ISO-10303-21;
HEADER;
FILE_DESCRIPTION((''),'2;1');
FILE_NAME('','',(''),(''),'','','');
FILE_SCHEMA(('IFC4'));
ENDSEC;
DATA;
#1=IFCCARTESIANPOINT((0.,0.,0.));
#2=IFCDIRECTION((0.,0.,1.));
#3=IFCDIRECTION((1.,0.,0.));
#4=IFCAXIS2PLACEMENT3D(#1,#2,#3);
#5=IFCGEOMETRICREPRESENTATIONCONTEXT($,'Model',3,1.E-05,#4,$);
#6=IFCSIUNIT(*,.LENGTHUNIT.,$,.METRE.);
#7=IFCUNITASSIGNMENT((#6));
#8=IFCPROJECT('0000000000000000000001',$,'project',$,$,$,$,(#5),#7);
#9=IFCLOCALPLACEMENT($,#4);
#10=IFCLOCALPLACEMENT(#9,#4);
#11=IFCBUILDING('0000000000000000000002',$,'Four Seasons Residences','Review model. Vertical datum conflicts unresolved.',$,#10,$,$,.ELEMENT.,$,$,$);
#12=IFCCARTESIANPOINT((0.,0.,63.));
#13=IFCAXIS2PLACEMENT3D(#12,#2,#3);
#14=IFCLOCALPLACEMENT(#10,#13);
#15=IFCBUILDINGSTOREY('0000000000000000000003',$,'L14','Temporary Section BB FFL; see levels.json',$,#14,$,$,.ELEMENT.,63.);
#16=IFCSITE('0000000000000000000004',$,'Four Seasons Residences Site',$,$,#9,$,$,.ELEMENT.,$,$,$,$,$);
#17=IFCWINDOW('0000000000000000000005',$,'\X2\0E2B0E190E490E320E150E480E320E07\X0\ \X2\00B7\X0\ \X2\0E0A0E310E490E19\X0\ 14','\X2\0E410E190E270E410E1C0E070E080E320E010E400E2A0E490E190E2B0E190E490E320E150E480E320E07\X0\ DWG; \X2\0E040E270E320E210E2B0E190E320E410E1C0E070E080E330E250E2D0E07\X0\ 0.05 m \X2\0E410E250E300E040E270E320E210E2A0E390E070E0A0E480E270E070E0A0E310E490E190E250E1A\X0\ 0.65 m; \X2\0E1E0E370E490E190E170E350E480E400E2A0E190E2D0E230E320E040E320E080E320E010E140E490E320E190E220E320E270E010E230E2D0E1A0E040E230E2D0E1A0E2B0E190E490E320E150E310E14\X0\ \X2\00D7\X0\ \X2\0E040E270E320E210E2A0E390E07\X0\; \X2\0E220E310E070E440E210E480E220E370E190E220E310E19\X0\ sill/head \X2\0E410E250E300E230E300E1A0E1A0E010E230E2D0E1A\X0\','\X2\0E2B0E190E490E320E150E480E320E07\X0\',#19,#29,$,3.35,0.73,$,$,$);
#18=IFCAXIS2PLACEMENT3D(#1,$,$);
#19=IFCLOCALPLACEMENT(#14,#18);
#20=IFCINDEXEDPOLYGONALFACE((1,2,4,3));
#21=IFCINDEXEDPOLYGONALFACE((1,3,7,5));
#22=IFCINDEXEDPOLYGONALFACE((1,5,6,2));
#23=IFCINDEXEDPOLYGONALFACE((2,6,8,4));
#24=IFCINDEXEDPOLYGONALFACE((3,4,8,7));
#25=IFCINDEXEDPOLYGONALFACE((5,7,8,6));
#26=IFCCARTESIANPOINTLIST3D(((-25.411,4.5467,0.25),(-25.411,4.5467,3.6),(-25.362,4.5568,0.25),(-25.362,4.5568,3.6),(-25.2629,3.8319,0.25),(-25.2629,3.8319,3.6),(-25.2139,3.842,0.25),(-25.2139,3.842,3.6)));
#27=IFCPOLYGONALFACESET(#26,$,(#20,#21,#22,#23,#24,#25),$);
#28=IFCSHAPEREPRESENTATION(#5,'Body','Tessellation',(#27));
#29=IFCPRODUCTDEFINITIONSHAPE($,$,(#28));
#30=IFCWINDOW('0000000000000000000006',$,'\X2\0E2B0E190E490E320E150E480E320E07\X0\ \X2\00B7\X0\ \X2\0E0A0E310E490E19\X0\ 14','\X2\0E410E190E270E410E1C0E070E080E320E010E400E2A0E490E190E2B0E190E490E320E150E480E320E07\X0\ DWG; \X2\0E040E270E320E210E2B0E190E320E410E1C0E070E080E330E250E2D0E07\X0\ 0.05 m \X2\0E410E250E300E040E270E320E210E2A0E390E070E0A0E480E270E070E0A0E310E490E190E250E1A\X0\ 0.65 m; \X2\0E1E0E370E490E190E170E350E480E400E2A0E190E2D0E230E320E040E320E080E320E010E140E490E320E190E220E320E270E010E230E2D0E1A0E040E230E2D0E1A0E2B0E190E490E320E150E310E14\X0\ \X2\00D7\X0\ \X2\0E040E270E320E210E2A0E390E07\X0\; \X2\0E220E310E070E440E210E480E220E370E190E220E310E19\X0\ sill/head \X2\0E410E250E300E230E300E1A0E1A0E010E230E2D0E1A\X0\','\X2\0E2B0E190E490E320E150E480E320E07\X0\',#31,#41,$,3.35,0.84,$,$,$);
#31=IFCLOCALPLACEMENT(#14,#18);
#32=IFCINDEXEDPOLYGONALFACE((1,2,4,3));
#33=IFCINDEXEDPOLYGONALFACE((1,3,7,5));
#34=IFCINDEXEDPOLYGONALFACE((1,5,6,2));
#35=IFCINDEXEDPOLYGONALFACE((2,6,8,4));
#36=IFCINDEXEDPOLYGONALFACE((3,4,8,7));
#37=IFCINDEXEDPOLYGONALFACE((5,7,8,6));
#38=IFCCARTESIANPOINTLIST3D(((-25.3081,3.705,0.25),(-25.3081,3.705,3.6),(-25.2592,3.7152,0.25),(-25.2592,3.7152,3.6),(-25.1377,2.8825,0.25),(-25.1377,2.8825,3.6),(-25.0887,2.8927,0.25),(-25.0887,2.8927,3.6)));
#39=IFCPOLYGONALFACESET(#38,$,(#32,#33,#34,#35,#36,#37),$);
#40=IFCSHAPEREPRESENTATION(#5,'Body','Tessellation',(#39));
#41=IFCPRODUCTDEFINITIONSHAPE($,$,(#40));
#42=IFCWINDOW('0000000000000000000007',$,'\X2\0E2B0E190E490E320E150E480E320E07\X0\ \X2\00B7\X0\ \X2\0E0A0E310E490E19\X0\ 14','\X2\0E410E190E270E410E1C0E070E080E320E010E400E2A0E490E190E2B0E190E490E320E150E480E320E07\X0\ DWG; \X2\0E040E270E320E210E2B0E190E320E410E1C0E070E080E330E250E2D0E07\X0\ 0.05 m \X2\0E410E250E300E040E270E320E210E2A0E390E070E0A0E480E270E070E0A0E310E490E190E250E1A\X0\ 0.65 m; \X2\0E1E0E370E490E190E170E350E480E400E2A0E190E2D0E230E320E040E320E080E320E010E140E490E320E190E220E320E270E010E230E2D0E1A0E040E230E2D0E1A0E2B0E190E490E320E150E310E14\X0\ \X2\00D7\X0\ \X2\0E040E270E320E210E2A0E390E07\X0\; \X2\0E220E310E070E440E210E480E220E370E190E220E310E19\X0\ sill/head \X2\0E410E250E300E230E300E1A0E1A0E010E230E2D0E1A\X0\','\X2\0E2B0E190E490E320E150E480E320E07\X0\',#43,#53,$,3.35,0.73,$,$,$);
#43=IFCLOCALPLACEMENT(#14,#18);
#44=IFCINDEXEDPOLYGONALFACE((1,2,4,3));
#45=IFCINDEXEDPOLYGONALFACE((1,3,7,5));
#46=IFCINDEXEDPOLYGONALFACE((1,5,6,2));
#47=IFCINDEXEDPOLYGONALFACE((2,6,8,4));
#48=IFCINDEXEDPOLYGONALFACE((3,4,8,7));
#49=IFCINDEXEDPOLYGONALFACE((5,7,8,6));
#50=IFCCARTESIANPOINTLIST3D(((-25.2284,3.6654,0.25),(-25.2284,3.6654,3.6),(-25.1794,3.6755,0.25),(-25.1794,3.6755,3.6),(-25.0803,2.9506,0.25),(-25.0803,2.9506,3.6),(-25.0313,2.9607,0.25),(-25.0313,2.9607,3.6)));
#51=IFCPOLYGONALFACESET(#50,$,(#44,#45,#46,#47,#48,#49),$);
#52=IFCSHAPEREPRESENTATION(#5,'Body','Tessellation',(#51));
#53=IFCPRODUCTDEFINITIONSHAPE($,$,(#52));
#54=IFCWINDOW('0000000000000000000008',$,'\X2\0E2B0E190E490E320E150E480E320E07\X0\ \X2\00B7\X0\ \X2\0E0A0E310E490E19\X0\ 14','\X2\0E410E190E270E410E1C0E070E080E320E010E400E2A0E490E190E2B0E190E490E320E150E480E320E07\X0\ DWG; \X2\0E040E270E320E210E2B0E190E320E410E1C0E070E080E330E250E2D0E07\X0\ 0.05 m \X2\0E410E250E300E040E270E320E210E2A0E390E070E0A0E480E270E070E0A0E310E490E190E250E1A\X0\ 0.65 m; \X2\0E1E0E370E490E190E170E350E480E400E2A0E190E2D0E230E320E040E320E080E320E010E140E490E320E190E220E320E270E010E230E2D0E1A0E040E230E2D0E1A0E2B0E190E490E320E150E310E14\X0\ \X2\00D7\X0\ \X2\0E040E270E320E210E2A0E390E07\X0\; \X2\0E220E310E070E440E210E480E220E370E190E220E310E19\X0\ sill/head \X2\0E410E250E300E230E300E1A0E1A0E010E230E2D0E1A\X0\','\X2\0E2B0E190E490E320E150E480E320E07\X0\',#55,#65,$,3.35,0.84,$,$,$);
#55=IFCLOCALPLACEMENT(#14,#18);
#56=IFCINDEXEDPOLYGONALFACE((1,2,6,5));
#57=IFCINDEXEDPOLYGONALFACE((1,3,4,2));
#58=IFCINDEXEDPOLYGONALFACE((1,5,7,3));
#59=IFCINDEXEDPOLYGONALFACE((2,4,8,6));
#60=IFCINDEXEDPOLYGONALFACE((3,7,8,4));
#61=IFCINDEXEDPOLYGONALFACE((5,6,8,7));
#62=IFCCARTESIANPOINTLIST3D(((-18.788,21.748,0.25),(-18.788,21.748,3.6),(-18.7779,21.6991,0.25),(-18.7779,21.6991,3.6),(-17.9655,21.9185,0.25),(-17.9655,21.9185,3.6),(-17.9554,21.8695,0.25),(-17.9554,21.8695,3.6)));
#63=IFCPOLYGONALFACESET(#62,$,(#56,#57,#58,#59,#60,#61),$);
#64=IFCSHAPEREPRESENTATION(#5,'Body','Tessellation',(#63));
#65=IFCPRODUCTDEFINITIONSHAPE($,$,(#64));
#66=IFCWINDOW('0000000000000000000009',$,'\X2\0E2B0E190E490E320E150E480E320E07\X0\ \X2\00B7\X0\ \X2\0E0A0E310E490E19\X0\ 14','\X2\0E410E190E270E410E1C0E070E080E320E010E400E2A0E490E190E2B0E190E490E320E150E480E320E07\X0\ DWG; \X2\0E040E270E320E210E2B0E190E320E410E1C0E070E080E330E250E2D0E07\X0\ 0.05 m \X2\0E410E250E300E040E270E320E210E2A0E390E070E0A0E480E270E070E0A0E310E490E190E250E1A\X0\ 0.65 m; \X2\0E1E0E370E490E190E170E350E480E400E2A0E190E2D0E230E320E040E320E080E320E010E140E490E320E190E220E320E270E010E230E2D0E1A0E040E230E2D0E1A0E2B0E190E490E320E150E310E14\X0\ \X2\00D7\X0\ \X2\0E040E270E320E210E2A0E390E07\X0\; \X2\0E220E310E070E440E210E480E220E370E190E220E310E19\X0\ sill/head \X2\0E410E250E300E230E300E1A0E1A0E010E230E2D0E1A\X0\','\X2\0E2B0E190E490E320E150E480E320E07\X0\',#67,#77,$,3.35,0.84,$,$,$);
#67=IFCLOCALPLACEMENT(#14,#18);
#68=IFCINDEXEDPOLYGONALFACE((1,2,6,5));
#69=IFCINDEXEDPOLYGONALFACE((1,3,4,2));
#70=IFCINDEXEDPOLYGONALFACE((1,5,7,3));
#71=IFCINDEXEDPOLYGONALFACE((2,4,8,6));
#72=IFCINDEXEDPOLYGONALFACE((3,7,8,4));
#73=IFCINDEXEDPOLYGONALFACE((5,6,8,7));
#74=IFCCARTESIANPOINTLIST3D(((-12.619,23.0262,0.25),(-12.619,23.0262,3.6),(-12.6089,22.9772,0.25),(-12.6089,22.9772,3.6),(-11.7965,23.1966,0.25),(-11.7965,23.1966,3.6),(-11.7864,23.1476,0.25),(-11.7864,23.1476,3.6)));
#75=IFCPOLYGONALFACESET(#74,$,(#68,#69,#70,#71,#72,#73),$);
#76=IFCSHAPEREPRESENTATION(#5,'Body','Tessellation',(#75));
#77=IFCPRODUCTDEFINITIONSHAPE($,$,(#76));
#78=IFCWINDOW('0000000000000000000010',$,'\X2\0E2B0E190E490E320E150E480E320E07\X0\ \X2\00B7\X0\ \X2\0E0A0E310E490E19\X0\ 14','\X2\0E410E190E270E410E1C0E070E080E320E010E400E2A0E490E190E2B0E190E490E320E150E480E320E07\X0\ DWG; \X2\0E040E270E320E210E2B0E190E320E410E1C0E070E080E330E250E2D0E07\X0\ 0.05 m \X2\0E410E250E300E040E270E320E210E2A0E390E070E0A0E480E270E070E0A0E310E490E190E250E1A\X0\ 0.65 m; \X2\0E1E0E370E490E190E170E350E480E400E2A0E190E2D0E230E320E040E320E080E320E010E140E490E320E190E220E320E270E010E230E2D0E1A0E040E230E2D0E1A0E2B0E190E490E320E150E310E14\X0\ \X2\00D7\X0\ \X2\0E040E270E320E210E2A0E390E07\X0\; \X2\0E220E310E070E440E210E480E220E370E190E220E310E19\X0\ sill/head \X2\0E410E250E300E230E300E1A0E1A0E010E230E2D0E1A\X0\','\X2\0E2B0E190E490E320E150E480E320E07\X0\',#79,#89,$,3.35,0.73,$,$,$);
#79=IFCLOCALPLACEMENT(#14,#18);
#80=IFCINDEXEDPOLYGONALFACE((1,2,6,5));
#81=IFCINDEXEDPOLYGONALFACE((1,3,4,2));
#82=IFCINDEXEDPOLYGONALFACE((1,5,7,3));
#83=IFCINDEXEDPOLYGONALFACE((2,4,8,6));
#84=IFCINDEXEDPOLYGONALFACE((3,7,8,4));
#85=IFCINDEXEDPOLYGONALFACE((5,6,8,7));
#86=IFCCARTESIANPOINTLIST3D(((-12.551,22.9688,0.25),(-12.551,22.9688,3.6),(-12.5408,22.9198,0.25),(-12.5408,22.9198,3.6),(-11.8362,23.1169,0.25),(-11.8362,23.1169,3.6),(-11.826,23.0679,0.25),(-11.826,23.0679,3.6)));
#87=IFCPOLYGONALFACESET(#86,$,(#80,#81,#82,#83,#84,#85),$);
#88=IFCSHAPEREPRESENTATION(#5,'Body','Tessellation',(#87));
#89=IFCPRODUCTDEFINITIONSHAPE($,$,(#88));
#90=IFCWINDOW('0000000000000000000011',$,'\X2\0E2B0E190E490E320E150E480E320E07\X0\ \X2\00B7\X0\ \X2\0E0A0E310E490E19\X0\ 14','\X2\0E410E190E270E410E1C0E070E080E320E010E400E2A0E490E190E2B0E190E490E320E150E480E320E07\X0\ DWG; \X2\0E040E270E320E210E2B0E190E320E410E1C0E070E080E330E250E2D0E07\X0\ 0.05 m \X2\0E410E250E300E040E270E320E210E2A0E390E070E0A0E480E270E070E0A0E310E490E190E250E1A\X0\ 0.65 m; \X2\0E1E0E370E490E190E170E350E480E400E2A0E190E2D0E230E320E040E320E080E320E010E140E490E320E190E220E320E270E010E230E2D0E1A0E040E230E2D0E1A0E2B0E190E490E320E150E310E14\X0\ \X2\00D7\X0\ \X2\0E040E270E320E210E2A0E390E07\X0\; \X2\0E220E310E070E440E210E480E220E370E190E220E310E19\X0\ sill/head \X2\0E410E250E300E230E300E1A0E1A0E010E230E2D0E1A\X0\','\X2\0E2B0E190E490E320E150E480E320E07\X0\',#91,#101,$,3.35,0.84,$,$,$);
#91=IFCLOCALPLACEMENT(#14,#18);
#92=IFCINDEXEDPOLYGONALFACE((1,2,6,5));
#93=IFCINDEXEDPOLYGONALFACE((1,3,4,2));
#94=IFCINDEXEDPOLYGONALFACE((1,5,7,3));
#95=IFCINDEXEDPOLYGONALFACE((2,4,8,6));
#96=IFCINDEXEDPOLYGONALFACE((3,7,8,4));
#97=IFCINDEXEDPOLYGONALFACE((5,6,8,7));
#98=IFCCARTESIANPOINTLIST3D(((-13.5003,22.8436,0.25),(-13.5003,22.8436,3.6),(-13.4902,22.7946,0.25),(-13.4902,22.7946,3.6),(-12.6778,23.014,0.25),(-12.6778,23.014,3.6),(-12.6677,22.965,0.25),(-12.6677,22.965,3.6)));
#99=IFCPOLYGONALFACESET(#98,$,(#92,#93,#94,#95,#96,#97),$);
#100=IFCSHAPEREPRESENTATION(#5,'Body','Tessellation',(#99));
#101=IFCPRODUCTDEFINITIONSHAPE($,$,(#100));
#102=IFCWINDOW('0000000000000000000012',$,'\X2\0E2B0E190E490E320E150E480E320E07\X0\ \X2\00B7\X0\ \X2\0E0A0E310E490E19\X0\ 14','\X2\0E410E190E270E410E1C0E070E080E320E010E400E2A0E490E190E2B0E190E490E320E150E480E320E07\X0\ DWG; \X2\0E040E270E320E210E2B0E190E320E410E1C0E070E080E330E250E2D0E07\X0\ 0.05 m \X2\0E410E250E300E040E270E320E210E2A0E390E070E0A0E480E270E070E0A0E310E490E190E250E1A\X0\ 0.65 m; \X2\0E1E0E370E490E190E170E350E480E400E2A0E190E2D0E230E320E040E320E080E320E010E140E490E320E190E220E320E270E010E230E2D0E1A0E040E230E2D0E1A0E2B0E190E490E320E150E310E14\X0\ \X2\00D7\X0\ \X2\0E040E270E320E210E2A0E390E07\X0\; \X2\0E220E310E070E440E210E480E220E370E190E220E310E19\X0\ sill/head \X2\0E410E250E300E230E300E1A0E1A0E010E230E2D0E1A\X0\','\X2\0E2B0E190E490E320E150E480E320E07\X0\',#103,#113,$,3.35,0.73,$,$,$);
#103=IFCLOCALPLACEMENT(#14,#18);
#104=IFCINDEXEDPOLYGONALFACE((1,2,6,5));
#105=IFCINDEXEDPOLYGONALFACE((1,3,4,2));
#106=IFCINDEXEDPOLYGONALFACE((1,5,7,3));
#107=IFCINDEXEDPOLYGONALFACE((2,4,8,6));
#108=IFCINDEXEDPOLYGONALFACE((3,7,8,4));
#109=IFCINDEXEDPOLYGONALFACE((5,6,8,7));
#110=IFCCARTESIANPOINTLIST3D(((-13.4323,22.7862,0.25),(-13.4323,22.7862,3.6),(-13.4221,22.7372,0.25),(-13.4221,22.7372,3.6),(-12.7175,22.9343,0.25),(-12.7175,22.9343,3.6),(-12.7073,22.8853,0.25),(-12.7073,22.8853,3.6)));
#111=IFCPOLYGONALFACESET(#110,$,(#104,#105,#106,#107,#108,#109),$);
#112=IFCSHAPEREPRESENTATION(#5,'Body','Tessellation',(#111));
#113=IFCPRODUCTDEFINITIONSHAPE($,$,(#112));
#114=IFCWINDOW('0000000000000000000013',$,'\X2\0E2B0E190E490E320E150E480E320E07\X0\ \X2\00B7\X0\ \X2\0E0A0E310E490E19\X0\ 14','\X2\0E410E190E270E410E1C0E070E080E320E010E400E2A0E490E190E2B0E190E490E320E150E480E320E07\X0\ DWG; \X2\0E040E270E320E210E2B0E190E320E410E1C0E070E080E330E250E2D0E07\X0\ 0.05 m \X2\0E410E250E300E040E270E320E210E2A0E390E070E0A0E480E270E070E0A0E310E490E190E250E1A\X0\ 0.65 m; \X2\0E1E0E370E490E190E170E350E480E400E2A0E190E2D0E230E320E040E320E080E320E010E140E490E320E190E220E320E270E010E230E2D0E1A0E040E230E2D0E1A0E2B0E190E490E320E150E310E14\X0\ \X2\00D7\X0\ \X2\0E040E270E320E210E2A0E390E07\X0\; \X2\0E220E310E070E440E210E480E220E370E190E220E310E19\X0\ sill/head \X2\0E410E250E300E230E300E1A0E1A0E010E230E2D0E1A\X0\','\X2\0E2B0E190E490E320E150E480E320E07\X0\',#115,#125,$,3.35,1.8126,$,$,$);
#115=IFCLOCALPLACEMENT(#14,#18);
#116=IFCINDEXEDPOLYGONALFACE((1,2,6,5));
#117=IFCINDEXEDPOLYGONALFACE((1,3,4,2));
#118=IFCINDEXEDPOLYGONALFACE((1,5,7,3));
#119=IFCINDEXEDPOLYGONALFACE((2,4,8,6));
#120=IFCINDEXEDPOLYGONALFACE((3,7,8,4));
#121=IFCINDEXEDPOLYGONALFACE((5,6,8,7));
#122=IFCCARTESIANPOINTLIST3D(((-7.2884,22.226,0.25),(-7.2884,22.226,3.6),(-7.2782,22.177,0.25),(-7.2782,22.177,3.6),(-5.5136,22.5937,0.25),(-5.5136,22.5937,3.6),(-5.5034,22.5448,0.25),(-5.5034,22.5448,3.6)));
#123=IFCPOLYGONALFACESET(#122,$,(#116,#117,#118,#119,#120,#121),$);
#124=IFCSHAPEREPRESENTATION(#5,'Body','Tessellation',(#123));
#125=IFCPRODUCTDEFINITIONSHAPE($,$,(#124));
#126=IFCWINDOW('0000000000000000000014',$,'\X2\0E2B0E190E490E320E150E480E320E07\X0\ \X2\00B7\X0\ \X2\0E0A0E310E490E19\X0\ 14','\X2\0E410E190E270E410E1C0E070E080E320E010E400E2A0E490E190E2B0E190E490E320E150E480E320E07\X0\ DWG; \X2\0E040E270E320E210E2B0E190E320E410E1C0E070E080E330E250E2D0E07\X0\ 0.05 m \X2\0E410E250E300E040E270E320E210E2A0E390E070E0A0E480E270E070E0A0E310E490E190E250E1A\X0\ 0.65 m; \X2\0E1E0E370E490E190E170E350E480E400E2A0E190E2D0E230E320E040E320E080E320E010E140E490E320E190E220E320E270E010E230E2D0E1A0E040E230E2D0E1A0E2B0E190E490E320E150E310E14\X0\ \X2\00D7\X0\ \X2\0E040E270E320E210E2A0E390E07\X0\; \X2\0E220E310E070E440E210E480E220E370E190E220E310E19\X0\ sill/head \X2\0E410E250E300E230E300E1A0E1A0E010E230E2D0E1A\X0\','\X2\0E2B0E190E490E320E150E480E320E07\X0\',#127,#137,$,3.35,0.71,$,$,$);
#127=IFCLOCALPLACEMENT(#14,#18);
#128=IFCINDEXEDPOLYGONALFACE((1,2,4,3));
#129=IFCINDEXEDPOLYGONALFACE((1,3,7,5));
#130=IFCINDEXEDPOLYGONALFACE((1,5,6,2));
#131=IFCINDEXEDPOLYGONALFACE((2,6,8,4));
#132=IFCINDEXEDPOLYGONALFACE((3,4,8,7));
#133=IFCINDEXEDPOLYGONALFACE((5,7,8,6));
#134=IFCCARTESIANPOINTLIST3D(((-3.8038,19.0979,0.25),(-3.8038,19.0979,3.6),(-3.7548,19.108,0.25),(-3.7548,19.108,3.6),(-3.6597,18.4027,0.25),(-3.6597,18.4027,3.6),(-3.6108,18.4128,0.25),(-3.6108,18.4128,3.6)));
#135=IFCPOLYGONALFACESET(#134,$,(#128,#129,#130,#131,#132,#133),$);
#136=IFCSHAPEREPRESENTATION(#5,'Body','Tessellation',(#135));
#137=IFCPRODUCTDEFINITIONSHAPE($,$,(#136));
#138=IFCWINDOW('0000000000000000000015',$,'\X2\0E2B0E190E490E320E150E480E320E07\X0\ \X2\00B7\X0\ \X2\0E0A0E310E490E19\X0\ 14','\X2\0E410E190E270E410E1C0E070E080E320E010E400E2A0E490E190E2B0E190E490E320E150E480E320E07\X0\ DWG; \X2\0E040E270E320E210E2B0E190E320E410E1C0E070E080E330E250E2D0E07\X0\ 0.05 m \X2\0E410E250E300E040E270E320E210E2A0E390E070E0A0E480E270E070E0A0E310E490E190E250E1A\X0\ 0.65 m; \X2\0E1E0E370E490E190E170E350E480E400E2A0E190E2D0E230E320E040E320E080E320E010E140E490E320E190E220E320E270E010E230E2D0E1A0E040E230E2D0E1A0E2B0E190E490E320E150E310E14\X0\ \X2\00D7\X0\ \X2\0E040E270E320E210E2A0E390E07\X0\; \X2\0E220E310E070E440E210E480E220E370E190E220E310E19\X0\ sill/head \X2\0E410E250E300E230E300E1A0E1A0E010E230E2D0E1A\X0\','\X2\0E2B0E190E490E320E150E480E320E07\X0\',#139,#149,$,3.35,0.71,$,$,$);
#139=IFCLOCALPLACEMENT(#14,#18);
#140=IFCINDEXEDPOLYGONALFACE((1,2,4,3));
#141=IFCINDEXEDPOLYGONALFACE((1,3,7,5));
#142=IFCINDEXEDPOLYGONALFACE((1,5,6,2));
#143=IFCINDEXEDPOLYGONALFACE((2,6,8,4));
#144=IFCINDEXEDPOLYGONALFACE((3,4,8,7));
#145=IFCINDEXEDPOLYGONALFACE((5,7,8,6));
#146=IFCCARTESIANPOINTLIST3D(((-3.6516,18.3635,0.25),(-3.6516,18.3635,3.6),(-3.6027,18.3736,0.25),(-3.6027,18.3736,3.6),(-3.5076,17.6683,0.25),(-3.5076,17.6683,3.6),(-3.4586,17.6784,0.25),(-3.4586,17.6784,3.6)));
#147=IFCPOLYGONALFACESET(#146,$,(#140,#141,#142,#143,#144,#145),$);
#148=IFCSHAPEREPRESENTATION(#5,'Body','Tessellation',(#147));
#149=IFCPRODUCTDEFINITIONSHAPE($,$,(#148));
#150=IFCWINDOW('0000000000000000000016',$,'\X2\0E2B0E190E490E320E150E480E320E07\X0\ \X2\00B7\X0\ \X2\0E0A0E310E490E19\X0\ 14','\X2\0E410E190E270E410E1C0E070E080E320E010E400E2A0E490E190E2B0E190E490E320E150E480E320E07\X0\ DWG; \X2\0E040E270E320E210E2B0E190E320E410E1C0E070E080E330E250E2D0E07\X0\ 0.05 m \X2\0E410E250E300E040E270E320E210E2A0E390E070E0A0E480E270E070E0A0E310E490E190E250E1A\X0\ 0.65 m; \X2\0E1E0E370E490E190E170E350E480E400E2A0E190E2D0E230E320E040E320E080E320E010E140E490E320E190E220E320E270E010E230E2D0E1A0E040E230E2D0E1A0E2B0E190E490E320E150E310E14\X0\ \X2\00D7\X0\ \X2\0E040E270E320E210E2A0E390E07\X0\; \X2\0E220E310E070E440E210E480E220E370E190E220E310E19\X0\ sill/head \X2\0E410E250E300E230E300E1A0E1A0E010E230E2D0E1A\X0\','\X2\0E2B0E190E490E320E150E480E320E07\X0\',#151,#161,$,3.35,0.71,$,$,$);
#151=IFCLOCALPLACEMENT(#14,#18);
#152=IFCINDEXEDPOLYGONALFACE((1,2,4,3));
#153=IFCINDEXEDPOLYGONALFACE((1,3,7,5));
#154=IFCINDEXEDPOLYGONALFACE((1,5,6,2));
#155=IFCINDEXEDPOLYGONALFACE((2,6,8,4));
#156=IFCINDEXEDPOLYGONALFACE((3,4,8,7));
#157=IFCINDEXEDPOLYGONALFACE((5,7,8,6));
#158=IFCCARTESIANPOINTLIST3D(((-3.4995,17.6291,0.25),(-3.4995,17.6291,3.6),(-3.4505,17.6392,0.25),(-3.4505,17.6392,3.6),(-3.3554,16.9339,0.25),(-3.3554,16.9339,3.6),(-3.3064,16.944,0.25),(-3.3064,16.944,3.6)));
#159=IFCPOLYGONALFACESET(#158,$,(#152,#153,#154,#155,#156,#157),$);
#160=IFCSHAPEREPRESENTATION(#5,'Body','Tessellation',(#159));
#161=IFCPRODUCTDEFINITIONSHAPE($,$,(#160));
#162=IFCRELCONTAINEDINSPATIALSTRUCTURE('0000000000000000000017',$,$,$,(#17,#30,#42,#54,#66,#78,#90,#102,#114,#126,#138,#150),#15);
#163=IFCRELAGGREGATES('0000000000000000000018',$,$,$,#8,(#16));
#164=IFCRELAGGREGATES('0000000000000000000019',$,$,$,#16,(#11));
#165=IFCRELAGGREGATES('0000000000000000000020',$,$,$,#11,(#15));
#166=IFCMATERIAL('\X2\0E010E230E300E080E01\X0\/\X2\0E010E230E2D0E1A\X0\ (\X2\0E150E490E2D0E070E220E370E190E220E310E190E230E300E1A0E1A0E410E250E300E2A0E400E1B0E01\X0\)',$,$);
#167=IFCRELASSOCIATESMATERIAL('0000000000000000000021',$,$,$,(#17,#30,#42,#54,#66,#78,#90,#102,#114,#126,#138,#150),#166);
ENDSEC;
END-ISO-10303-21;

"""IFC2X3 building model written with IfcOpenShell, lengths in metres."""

from ifc_helpers import new_model, si_unit, frame, origin_with_axes, place, context, project, spatial, polyline, outline, extrude, material, element, save


model = new_model("IFC2X3")

# Units and contexts
model_context = context("Model", 3, precision=1e-05, world=origin_with_axes())
ifc_project = project(units=[si_unit("LENGTHUNIT", "METRE")], contexts=[model_context])

# Site, building, storey
site_placement = place(None, origin_with_axes())
site = spatial("IfcSite", under=ifc_project, at=site_placement, Name="Four Seasons Residences Site", CompositionType="ELEMENT")
building_placement = place(site_placement, origin_with_axes())
building = spatial("IfcBuilding", under=site, at=building_placement, Name="Four Seasons Residences", Description="Review model. Vertical datum conflicts unresolved.", CompositionType="ELEMENT")
storey_placement = place(building_placement, frame((0.0, 0.0, 63.0), z_axis=(0.0, 0.0, 1.0), x_axis=(1.0, 0.0, 0.0)))
storey = spatial("IfcBuildingStorey", under=building, at=storey_placement, Name="L14", Description="Temporary Section BB FFL; see levels.json", CompositionType="ELEMENT", Elevation=63.0)

# Windows
ifc_material = material(Name="กระจก/กรอบ (ต้องยืนยันระบบและสเปก)")
window_1_placement = place(storey_placement, origin_with_axes())
element("IfcWindow", 1, at=window_1_placement, inside=storey, material=ifc_material, Name="หน้าต่าง · ชั้น 14", Description="แนวแผงจากเส้นหน้าต่าง DWG; ความหนาแผงจำลอง 0.05 m และความสูงช่วงชั้นลบ 0.65 m; พื้นที่เสนอราคาจากด้านยาวกรอบครอบหน้าตัด × ความสูง; ยังไม่ยืนยัน sill/head และระบบกรอบ", ObjectType="หน้าต่าง", OverallHeight=3.35, OverallWidth=0.73, context=model_context, shape_type="SweptSolid", body=[
    extrude(outline(polyline([(-25.2139, 3.842), (-25.2629, 3.8319), (-25.411, 4.5467), (-25.362, 4.5568), (-25.2139, 3.842)])), frame((0.0, 0.0, 0.25), z_axis=(0.0, 0.0, 1.0), x_axis=(1.0, 0.0, 0.0)), (0.0, 0.0, 1.0), 3.35),
])
window_2_placement = place(storey_placement, origin_with_axes())
element("IfcWindow", 2, at=window_2_placement, inside=storey, material=ifc_material, Name="หน้าต่าง · ชั้น 14", Description="แนวแผงจากเส้นหน้าต่าง DWG; ความหนาแผงจำลอง 0.05 m และความสูงช่วงชั้นลบ 0.65 m; พื้นที่เสนอราคาจากด้านยาวกรอบครอบหน้าตัด × ความสูง; ยังไม่ยืนยัน sill/head และระบบกรอบ", ObjectType="หน้าต่าง", OverallHeight=3.35, OverallWidth=0.84, context=model_context, shape_type="SweptSolid", body=[
    extrude(outline(polyline([(-25.0887, 2.8927), (-25.1377, 2.8825), (-25.3081, 3.705), (-25.2592, 3.7152), (-25.0887, 2.8927)])), frame((0.0, 0.0, 0.25), z_axis=(0.0, 0.0, 1.0), x_axis=(1.0, 0.0, 0.0)), (0.0, 0.0, 1.0), 3.35),
])
window_3_placement = place(storey_placement, origin_with_axes())
element("IfcWindow", 3, at=window_3_placement, inside=storey, material=ifc_material, Name="หน้าต่าง · ชั้น 14", Description="แนวแผงจากเส้นหน้าต่าง DWG; ความหนาแผงจำลอง 0.05 m และความสูงช่วงชั้นลบ 0.65 m; พื้นที่เสนอราคาจากด้านยาวกรอบครอบหน้าตัด × ความสูง; ยังไม่ยืนยัน sill/head และระบบกรอบ", ObjectType="หน้าต่าง", OverallHeight=3.35, OverallWidth=0.73, context=model_context, shape_type="SweptSolid", body=[
    extrude(outline(polyline([(-25.0313, 2.9607), (-25.0803, 2.9506), (-25.2284, 3.6654), (-25.1794, 3.6755), (-25.0313, 2.9607)])), frame((0.0, 0.0, 0.25), z_axis=(0.0, 0.0, 1.0), x_axis=(1.0, 0.0, 0.0)), (0.0, 0.0, 1.0), 3.35),
])
window_4_placement = place(storey_placement, origin_with_axes())
element("IfcWindow", 4, at=window_4_placement, inside=storey, material=ifc_material, Name="หน้าต่าง · ชั้น 14", Description="แนวแผงจากเส้นหน้าต่าง DWG; ความหนาแผงจำลอง 0.05 m และความสูงช่วงชั้นลบ 0.65 m; พื้นที่เสนอราคาจากด้านยาวกรอบครอบหน้าตัด × ความสูง; ยังไม่ยืนยัน sill/head และระบบกรอบ", ObjectType="หน้าต่าง", OverallHeight=3.35, OverallWidth=0.84, context=model_context, shape_type="SweptSolid", body=[
    extrude(outline(polyline([(-17.9655, 21.9185), (-17.9554, 21.8695), (-18.7779, 21.6991), (-18.788, 21.748), (-17.9655, 21.9185)])), frame((0.0, 0.0, 0.25), z_axis=(0.0, 0.0, 1.0), x_axis=(1.0, 0.0, 0.0)), (0.0, 0.0, 1.0), 3.35),
])
window_5_placement = place(storey_placement, origin_with_axes())
element("IfcWindow", 5, at=window_5_placement, inside=storey, material=ifc_material, Name="หน้าต่าง · ชั้น 14", Description="แนวแผงจากเส้นหน้าต่าง DWG; ความหนาแผงจำลอง 0.05 m และความสูงช่วงชั้นลบ 0.65 m; พื้นที่เสนอราคาจากด้านยาวกรอบครอบหน้าตัด × ความสูง; ยังไม่ยืนยัน sill/head และระบบกรอบ", ObjectType="หน้าต่าง", OverallHeight=3.35, OverallWidth=0.84, context=model_context, shape_type="SweptSolid", body=[
    extrude(outline(polyline([(-12.6089, 22.9772), (-12.619, 23.0262), (-11.7965, 23.1966), (-11.7864, 23.1476), (-12.6089, 22.9772)])), frame((0.0, 0.0, 0.25), z_axis=(0.0, 0.0, 1.0), x_axis=(1.0, 0.0, 0.0)), (0.0, 0.0, 1.0), 3.35),
])
window_6_placement = place(storey_placement, origin_with_axes())
element("IfcWindow", 6, at=window_6_placement, inside=storey, material=ifc_material, Name="หน้าต่าง · ชั้น 14", Description="แนวแผงจากเส้นหน้าต่าง DWG; ความหนาแผงจำลอง 0.05 m และความสูงช่วงชั้นลบ 0.65 m; พื้นที่เสนอราคาจากด้านยาวกรอบครอบหน้าตัด × ความสูง; ยังไม่ยืนยัน sill/head และระบบกรอบ", ObjectType="หน้าต่าง", OverallHeight=3.35, OverallWidth=0.73, context=model_context, shape_type="SweptSolid", body=[
    extrude(outline(polyline([(-12.5408, 22.9198), (-12.551, 22.9688), (-11.8362, 23.1169), (-11.826, 23.0679), (-12.5408, 22.9198)])), frame((0.0, 0.0, 0.25), z_axis=(0.0, 0.0, 1.0), x_axis=(1.0, 0.0, 0.0)), (0.0, 0.0, 1.0), 3.35),
])
window_7_placement = place(storey_placement, origin_with_axes())
element("IfcWindow", 7, at=window_7_placement, inside=storey, material=ifc_material, Name="หน้าต่าง · ชั้น 14", Description="แนวแผงจากเส้นหน้าต่าง DWG; ความหนาแผงจำลอง 0.05 m และความสูงช่วงชั้นลบ 0.65 m; พื้นที่เสนอราคาจากด้านยาวกรอบครอบหน้าตัด × ความสูง; ยังไม่ยืนยัน sill/head และระบบกรอบ", ObjectType="หน้าต่าง", OverallHeight=3.35, OverallWidth=0.84, context=model_context, shape_type="SweptSolid", body=[
    extrude(outline(polyline([(-13.4902, 22.7946), (-13.5003, 22.8436), (-12.6778, 23.014), (-12.6677, 22.965), (-13.4902, 22.7946)])), frame((0.0, 0.0, 0.25), z_axis=(0.0, 0.0, 1.0), x_axis=(1.0, 0.0, 0.0)), (0.0, 0.0, 1.0), 3.35),
])
window_8_placement = place(storey_placement, origin_with_axes())
element("IfcWindow", 8, at=window_8_placement, inside=storey, material=ifc_material, Name="หน้าต่าง · ชั้น 14", Description="แนวแผงจากเส้นหน้าต่าง DWG; ความหนาแผงจำลอง 0.05 m และความสูงช่วงชั้นลบ 0.65 m; พื้นที่เสนอราคาจากด้านยาวกรอบครอบหน้าตัด × ความสูง; ยังไม่ยืนยัน sill/head และระบบกรอบ", ObjectType="หน้าต่าง", OverallHeight=3.35, OverallWidth=0.73, context=model_context, shape_type="SweptSolid", body=[
    extrude(outline(polyline([(-13.4221, 22.7372), (-13.4323, 22.7862), (-12.7175, 22.9343), (-12.7073, 22.8853), (-13.4221, 22.7372)])), frame((0.0, 0.0, 0.25), z_axis=(0.0, 0.0, 1.0), x_axis=(1.0, 0.0, 0.0)), (0.0, 0.0, 1.0), 3.35),
])
window_9_placement = place(storey_placement, origin_with_axes())
element("IfcWindow", 9, at=window_9_placement, inside=storey, material=ifc_material, Name="หน้าต่าง · ชั้น 14", Description="แนวแผงจากเส้นหน้าต่าง DWG; ความหนาแผงจำลอง 0.05 m และความสูงช่วงชั้นลบ 0.65 m; พื้นที่เสนอราคาจากด้านยาวกรอบครอบหน้าตัด × ความสูง; ยังไม่ยืนยัน sill/head และระบบกรอบ", ObjectType="หน้าต่าง", OverallHeight=3.35, OverallWidth=1.8126, context=model_context, shape_type="SweptSolid", body=[
    extrude(outline(polyline([(-7.2782, 22.177), (-7.2884, 22.226), (-5.5136, 22.5937), (-5.5034, 22.5448), (-7.2782, 22.177)])), frame((0.0, 0.0, 0.25), z_axis=(0.0, 0.0, 1.0), x_axis=(1.0, 0.0, 0.0)), (0.0, 0.0, 1.0), 3.35),
])
window_10_placement = place(storey_placement, origin_with_axes())
element("IfcWindow", 10, at=window_10_placement, inside=storey, material=ifc_material, Name="หน้าต่าง · ชั้น 14", Description="แนวแผงจากเส้นหน้าต่าง DWG; ความหนาแผงจำลอง 0.05 m และความสูงช่วงชั้นลบ 0.65 m; พื้นที่เสนอราคาจากด้านยาวกรอบครอบหน้าตัด × ความสูง; ยังไม่ยืนยัน sill/head และระบบกรอบ", ObjectType="หน้าต่าง", OverallHeight=3.35, OverallWidth=0.71, context=model_context, shape_type="SweptSolid", body=[
    extrude(outline(polyline([(-3.6108, 18.4128), (-3.6597, 18.4027), (-3.8038, 19.0979), (-3.7548, 19.108), (-3.6108, 18.4128)])), frame((0.0, 0.0, 0.25), z_axis=(0.0, 0.0, 1.0), x_axis=(1.0, 0.0, 0.0)), (0.0, 0.0, 1.0), 3.35),
])
window_11_placement = place(storey_placement, origin_with_axes())
element("IfcWindow", 11, at=window_11_placement, inside=storey, material=ifc_material, Name="หน้าต่าง · ชั้น 14", Description="แนวแผงจากเส้นหน้าต่าง DWG; ความหนาแผงจำลอง 0.05 m และความสูงช่วงชั้นลบ 0.65 m; พื้นที่เสนอราคาจากด้านยาวกรอบครอบหน้าตัด × ความสูง; ยังไม่ยืนยัน sill/head และระบบกรอบ", ObjectType="หน้าต่าง", OverallHeight=3.35, OverallWidth=0.71, context=model_context, shape_type="SweptSolid", body=[
    extrude(outline(polyline([(-3.4586, 17.6784), (-3.5076, 17.6683), (-3.6516, 18.3635), (-3.6027, 18.3736), (-3.4586, 17.6784)])), frame((0.0, 0.0, 0.25), z_axis=(0.0, 0.0, 1.0), x_axis=(1.0, 0.0, 0.0)), (0.0, 0.0, 1.0), 3.35),
])
window_12_placement = place(storey_placement, origin_with_axes())
element("IfcWindow", 12, at=window_12_placement, inside=storey, material=ifc_material, Name="หน้าต่าง · ชั้น 14", Description="แนวแผงจากเส้นหน้าต่าง DWG; ความหนาแผงจำลอง 0.05 m และความสูงช่วงชั้นลบ 0.65 m; พื้นที่เสนอราคาจากด้านยาวกรอบครอบหน้าตัด × ความสูง; ยังไม่ยืนยัน sill/head และระบบกรอบ", ObjectType="หน้าต่าง", OverallHeight=3.35, OverallWidth=0.71, context=model_context, shape_type="SweptSolid", body=[
    extrude(outline(polyline([(-3.3064, 16.944), (-3.3554, 16.9339), (-3.4995, 17.6291), (-3.4505, 17.6392), (-3.3064, 16.944)])), frame((0.0, 0.0, 0.25), z_axis=(0.0, 0.0, 1.0), x_axis=(1.0, 0.0, 0.0)), (0.0, 0.0, 1.0), 3.35),
])

save(model, "model.ifc")
